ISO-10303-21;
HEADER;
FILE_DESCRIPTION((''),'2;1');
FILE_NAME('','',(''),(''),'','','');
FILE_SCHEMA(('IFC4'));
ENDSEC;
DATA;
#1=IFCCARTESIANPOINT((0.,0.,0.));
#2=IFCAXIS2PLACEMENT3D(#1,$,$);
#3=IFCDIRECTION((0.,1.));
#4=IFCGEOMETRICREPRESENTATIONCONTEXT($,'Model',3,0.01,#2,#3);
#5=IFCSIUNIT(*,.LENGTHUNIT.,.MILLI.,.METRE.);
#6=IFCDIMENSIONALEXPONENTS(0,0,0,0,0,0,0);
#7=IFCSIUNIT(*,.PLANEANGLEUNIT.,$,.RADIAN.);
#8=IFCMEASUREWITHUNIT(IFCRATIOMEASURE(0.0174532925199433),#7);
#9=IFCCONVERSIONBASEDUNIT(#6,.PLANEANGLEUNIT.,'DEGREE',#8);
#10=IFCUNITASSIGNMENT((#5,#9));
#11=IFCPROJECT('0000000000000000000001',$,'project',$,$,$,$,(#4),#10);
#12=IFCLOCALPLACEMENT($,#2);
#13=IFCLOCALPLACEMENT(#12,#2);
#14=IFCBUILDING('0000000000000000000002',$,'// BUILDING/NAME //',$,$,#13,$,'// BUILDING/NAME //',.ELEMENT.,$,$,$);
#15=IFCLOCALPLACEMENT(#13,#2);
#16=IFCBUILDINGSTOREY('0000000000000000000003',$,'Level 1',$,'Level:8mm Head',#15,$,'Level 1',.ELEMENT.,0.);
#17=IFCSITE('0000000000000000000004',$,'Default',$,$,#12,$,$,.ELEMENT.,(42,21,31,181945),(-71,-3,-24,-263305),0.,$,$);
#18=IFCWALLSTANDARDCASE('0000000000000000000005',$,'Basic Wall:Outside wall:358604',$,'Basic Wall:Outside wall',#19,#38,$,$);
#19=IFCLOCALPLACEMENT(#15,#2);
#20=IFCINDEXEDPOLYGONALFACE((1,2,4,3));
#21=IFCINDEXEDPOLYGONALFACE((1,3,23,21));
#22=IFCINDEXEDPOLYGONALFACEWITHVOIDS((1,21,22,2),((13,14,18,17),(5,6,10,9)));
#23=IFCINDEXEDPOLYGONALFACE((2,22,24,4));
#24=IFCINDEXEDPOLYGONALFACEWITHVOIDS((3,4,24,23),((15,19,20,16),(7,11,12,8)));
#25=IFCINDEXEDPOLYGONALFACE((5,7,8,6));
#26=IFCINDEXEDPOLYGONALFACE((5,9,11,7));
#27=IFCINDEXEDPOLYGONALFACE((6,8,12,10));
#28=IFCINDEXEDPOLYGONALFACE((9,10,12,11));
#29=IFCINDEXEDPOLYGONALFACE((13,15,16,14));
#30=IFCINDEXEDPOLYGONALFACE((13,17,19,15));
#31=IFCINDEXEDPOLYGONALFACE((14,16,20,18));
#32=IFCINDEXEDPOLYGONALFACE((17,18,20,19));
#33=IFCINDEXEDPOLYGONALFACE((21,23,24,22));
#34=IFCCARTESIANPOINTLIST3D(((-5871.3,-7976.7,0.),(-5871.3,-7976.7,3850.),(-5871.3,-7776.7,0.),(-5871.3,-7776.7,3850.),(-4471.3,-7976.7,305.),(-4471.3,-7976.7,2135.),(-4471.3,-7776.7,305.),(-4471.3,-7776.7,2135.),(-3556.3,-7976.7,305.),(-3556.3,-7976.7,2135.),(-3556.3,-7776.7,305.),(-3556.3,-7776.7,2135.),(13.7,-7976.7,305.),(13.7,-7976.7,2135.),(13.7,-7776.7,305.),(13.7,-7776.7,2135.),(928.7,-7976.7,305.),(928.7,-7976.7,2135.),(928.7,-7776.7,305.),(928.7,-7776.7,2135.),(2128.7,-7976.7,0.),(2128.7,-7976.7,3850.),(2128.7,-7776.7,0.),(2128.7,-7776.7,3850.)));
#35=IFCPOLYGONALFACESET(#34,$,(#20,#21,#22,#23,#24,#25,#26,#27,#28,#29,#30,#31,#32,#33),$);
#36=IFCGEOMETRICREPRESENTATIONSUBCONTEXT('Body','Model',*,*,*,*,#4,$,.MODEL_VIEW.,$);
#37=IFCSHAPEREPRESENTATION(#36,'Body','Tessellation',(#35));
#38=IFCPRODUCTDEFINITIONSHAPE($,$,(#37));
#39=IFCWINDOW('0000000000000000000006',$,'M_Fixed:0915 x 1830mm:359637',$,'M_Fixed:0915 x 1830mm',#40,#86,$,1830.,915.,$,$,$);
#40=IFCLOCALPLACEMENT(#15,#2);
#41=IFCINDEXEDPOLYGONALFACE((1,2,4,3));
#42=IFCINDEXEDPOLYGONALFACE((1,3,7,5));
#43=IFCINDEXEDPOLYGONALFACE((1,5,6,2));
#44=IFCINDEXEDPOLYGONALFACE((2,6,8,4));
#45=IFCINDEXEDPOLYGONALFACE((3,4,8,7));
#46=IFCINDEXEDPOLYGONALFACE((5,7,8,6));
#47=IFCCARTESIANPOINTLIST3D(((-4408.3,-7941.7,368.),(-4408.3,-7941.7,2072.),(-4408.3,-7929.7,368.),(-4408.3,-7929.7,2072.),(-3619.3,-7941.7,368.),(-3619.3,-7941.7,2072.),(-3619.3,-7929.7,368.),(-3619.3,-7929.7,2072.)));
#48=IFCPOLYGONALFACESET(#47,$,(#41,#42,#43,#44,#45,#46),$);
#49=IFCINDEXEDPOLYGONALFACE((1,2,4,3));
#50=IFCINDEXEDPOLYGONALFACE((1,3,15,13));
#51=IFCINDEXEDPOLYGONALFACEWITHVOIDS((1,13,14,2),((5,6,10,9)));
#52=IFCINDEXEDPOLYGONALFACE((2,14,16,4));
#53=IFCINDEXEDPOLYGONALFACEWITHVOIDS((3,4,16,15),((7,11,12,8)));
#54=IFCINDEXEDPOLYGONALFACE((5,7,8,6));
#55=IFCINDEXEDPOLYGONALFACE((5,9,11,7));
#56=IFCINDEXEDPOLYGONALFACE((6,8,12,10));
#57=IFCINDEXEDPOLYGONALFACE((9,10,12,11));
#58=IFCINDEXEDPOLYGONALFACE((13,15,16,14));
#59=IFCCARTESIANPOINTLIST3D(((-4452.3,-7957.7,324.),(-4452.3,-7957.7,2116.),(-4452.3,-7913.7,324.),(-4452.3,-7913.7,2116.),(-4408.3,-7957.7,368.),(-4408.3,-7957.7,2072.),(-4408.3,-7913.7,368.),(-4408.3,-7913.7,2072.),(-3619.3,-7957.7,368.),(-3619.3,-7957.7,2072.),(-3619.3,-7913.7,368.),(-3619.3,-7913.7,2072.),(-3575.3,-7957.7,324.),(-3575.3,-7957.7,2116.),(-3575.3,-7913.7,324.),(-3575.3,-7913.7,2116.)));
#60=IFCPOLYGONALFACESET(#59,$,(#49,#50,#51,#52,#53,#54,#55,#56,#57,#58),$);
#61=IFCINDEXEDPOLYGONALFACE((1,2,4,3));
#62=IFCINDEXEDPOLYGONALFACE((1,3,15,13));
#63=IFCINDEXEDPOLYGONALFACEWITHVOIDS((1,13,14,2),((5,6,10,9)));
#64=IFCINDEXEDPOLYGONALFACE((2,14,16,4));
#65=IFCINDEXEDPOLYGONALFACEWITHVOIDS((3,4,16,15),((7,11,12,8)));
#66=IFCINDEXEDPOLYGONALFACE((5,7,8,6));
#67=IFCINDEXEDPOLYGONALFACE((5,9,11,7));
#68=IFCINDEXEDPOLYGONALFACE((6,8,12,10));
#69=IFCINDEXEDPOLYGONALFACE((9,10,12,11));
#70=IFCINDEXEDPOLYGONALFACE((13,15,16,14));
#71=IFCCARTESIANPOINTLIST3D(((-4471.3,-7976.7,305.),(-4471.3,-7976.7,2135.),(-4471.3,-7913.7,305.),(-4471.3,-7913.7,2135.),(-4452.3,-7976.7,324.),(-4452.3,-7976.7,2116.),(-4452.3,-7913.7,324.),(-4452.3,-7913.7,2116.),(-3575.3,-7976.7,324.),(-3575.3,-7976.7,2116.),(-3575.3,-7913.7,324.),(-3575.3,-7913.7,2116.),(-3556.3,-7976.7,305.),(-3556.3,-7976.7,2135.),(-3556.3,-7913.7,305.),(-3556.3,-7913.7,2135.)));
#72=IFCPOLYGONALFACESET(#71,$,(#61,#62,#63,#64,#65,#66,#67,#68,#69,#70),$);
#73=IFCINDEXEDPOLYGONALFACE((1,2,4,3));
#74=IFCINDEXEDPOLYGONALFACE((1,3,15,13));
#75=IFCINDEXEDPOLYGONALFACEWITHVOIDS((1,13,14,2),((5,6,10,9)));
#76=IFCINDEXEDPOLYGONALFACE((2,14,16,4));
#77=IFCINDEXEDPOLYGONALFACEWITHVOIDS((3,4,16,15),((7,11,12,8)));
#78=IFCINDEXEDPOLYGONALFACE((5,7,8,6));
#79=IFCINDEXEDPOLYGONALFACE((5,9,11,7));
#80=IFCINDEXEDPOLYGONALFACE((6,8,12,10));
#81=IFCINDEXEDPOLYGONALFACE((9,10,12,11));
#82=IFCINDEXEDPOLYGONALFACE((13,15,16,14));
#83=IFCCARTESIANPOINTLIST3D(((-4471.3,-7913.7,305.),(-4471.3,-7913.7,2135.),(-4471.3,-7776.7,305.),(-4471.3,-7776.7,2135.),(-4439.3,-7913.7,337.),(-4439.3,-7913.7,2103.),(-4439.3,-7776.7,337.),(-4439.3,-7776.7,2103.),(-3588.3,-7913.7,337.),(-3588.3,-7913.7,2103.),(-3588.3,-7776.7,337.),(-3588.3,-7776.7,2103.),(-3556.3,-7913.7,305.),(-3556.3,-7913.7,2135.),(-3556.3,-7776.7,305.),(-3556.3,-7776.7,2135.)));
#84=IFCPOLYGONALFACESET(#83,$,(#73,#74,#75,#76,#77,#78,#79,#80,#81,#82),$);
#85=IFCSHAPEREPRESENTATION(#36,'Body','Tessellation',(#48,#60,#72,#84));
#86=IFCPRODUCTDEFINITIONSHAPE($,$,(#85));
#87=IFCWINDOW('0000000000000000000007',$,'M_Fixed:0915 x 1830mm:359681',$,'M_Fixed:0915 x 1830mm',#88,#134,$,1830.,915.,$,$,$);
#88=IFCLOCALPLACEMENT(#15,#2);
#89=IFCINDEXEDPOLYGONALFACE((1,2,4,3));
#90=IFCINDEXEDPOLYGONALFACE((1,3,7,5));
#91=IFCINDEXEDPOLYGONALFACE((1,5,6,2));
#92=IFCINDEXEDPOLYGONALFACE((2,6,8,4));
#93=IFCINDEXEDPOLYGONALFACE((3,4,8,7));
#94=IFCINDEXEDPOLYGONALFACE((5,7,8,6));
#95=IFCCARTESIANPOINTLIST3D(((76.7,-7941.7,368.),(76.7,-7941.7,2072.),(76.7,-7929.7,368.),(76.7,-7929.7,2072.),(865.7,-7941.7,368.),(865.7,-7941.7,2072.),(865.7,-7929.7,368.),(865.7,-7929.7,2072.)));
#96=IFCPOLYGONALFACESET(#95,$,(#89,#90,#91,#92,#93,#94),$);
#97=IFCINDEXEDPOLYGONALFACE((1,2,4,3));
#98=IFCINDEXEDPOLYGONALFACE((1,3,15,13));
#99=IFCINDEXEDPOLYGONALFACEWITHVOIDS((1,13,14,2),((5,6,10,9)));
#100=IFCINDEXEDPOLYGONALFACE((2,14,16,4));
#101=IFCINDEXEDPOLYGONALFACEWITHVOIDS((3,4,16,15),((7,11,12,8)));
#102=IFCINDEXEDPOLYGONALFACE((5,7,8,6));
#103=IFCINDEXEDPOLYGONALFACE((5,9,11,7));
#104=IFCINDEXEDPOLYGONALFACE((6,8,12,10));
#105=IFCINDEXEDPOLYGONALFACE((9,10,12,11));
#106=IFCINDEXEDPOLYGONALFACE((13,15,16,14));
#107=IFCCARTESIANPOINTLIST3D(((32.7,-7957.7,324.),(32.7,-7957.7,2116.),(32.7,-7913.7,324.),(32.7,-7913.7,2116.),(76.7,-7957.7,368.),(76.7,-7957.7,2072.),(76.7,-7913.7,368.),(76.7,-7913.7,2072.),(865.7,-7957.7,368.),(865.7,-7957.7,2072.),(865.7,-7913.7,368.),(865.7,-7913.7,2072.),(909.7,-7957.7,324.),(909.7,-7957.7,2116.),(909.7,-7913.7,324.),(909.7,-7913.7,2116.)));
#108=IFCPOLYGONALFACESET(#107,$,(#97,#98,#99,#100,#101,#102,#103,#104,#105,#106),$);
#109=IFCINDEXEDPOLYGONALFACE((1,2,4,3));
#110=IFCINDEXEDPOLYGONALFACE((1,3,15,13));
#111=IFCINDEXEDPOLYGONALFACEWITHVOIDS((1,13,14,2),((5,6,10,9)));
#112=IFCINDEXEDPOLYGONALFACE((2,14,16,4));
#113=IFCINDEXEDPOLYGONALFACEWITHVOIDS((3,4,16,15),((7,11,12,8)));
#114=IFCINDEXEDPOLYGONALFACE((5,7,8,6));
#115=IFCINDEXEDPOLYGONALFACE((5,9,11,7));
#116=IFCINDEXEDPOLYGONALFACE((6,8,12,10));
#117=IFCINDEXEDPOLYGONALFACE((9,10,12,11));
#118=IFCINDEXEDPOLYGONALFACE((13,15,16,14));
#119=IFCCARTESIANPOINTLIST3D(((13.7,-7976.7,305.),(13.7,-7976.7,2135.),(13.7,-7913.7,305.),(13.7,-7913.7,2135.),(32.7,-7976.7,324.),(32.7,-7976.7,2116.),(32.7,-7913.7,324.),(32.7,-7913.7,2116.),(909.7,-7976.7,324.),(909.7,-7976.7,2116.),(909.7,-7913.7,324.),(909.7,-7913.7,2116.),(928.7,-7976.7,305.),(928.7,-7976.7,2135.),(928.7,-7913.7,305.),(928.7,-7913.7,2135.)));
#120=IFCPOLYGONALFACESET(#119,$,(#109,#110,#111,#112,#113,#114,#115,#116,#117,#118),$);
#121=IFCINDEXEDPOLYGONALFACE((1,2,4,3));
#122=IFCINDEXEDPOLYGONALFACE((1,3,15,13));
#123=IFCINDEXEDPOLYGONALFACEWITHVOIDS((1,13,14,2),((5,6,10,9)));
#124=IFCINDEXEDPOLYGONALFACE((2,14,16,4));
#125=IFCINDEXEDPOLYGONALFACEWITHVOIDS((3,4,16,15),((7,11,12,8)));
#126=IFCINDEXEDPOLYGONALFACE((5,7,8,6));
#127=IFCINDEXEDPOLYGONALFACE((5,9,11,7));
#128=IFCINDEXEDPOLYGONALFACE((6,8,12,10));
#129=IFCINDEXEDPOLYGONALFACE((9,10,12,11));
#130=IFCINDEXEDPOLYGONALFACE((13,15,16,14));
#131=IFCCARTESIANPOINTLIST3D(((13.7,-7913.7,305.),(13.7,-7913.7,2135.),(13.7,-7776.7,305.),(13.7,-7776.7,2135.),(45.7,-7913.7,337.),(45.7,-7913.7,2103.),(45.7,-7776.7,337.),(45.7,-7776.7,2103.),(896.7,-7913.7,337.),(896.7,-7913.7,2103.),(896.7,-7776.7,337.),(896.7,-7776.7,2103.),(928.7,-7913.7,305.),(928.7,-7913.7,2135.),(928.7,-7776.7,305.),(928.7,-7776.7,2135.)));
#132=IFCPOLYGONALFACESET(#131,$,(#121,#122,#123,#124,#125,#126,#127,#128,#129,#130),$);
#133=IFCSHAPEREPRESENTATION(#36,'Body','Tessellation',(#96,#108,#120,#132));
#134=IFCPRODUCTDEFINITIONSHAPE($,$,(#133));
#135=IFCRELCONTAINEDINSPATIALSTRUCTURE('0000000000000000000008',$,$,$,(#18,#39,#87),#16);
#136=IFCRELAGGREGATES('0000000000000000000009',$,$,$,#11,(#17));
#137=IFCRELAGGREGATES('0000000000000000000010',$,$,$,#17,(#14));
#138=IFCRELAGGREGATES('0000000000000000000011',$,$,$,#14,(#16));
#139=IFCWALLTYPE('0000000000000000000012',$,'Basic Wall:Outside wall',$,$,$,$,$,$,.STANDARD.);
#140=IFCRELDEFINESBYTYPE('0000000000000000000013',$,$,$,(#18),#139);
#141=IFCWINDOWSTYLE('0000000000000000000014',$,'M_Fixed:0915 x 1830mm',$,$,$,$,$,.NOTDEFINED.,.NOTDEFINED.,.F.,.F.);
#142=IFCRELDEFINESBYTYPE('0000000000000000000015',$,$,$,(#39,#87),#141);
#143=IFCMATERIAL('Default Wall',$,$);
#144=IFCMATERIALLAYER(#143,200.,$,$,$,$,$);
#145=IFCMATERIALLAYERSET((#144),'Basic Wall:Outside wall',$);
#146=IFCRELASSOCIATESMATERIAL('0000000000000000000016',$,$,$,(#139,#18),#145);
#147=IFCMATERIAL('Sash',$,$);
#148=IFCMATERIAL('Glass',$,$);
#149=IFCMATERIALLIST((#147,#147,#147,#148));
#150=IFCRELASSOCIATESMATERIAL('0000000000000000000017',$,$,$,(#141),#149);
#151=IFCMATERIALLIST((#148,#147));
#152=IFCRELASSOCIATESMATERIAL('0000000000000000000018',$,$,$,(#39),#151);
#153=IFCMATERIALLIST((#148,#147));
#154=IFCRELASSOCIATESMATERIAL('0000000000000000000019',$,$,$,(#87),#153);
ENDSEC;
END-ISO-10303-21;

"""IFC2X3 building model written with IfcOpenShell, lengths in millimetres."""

from ifc_helpers import new_model, entity, si_unit, converted_unit, direction, frame, frame_2d, origin, place, context, subcontext, project, spatial, polyline, rectangle, outline, extrude, clip, halfspace, bounded_halfspace, source, transform, mapped, material, material_list, layer, layer_set, layer_usage, type_object, type_shapes, element, fill, save


model = new_model("IFC2X3")

# Units and contexts
model_context = context("Model", 3, precision=0.01, world=origin(), true_north=direction((0.0, 1.0)))
body_context = subcontext(model_context, "Body", "Model", "MODEL_VIEW")
ifc_project = project(units=[si_unit("LENGTHUNIT", "METRE", prefix="MILLI"), converted_unit("PLANEANGLEUNIT", "DEGREE", entity("IfcRatioMeasure", 0.0174532925199433), si_unit("PLANEANGLEUNIT", "RADIAN"), dimensions=[0, 0, 0, 0, 0, 0, 0])], contexts=[model_context])

# Site, building, storey
site_placement = place(None, origin())
site = spatial("IfcSite", under=ifc_project, at=site_placement, Name="Default", CompositionType="ELEMENT", RefLatitude=(42, 21, 31, 181945), RefLongitude=(-71, -3, -24, -263305), RefElevation=0.0)
building_placement = place(site_placement, origin())
building = spatial("IfcBuilding", under=site, at=building_placement, Name="// BUILDING/NAME //", LongName="// BUILDING/NAME //", CompositionType="ELEMENT")
storey_placement = place(building_placement, origin())
storey = spatial("IfcBuildingStorey", under=building, at=storey_placement, Name="Level 1", ObjectType="Level:8mm Head", LongName="Level 1", CompositionType="ELEMENT", Elevation=0.0)

# Shared definitions
ifc_material_1 = material(Name="Default Wall")
ifc_layer_1 = layer(ifc_material_1, 200.0)
ifc_layer_set_1 = layer_set([ifc_layer_1], Name="Basic Wall:Outside wall")
wall_type_1 = type_object("IfcWallType", Name="Basic Wall:Outside wall", PredefinedType="STANDARD", material=ifc_layer_set_1)
ifc_material_2 = material(Name="Glass")
ifc_material_3 = material(Name="Sash")
ifc_material_list_1 = material_list([ifc_material_3, ifc_material_3, ifc_material_3, ifc_material_2])
window_style = type_object("IfcWindowStyle", Name="M_Fixed:0915 x 1830mm", ConstructionType="NOTDEFINED", OperationType="NOTDEFINED", ParameterTakesPrecedence=False, Sizeable=False, material=ifc_material_list_1)
shared_shape_1 = source(origin(), body_context, "Body", "SweptSolid", [
    extrude(rectangle(XDim=12.0, YDim=789.0, at=frame_2d((0.0, 0.0), x_axis=(1.0, 0.0))), frame((457.5, 159.0, 63.0), z_axis=(0.0, 0.0, 1.0), x_axis=(0.0, -1.0, 0.0)), (0.0, 0.0, 1.0), 1704.0),
    extrude(outline(polyline([(-438.5, -896.0), (438.5, -896.0), (438.5, 896.0), (-438.5, 896.0), (-438.5, -896.0)]), holes=[polyline([(-394.5, -852.0), (-394.5, 852.0), (394.5, 852.0), (394.5, -852.0), (-394.5, -852.0)])]), frame((457.5, 137.0, 915.0), z_axis=(0.0, 1.0, 0.0), x_axis=(1.0, 0.0, 0.0)), (0.0, 0.0, 1.0), 44.0),
    extrude(outline(polyline([(-457.5, -915.0), (457.5, -915.0), (457.5, 915.0), (-457.5, 915.0), (-457.5, -915.0)]), holes=[polyline([(-438.5, -896.0), (-438.5, 896.0), (438.5, 896.0), (438.5, -896.0), (-438.5, -896.0)])]), frame((457.5, 137.0, 915.0), z_axis=(0.0, 1.0, 0.0), x_axis=(1.0, 0.0, 0.0)), (0.0, 0.0, 1.0), 63.0),
    extrude(outline(polyline([(-457.5, -915.0), (457.5, -915.0), (457.5, 915.0), (-457.5, 915.0), (-457.5, -915.0)]), holes=[polyline([(-425.5, -883.0), (-425.5, 883.0), (425.5, 883.0), (425.5, -883.0), (-425.5, -883.0)])]), frame((457.5, 0.0, 915.0), z_axis=(0.0, 1.0, 0.0), x_axis=(1.0, 0.0, 0.0)), (0.0, 0.0, 1.0), 137.0),
])
type_shapes(window_style, [shared_shape_1])

# Wall, openings, windows
ifc_layer_usage_1 = layer_usage(ifc_layer_set_1, "AXIS2", "NEGATIVE", 100.0)
wall_1_placement = place(storey_placement, frame((2128.7, -7876.7, 0.0), z_axis=(0.0, 0.0, 1.0), x_axis=(-1.0, 0.0, 0.0)))
wall_1 = element("IfcWallStandardCase", 1, at=wall_1_placement, inside=storey, type_object=wall_type_1, material=ifc_layer_usage_1, Name="Basic Wall:Outside wall:358604", ObjectType="Basic Wall:Outside wall", context=body_context, shape_type="Clipping", body=[
    clip(clip(extrude(rectangle(XDim=8000.0, YDim=200.0, at=frame_2d((4000.0, 0.0), x_axis=(-1.0, 0.0))), origin(), (0.0, 0.0, 1.0), 3850.0), bounded_halfspace(frame((0.0, -100.0, 3850.0), z_axis=(0.0, 0.0, -1.0), x_axis=(0.0, 1.0, 0.0)), True, frame((0.0, -100.0, 3850.0), z_axis=(0.0, 0.0, -1.0), x_axis=(0.0, 1.0, 0.0)), polyline([(0.0, 0.0), (200.0, 0.0), (200.0, 8000.0), (0.0, 8000.0), (0.0, 7800.0), (0.0, 0.0)]))), halfspace(origin(), True)),
])
opening_1_placement = place(wall_1_placement, frame((5685.0, -100.0, 305.0)))
opening_1 = element("IfcOpeningElement", 2, at=opening_1_placement, cuts=wall_1, ObjectType="Opening", context=body_context, shape_type="SweptSolid", body=[
    extrude(rectangle(XDim=1830.0, YDim=915.0, at=frame_2d((915.0, 457.5), x_axis=(1.0, 0.0))), frame((0.0, 0.0, 0.0), z_axis=(0.0, 1.0, 0.0), x_axis=(0.0, 0.0, 1.0)), (0.0, 0.0, 1.0), 200.0),
])
opening_2_placement = place(wall_1_placement, frame((1200.0, -100.0, 305.0)))
opening_2 = element("IfcOpeningElement", 3, at=opening_2_placement, cuts=wall_1, ObjectType="Opening", context=body_context, shape_type="SweptSolid", body=[
    extrude(rectangle(XDim=1830.0, YDim=915.0, at=frame_2d((915.0, 457.5), x_axis=(1.0, 0.0))), frame((0.0, 0.0, 0.0), z_axis=(0.0, 1.0, 0.0), x_axis=(0.0, 0.0, 1.0)), (0.0, 0.0, 1.0), 200.0),
])
ifc_material_list_2 = material_list([ifc_material_2, ifc_material_3])
window_1_placement = place(opening_1_placement, origin())
window_1 = element("IfcWindow", 4, at=window_1_placement, inside=storey, type_object=window_style, material=ifc_material_list_2, Name="M_Fixed:0915 x 1830mm:359637", ObjectType="M_Fixed:0915 x 1830mm", OverallHeight=1830.0, OverallWidth=915.0, context=body_context, shape_type="MappedRepresentation", body=[
    mapped(shared_shape_1, transform((0.0, 0.0, 0.0), scale=1.0)),
])
fill(opening_1, window_1)
ifc_material_list_3 = material_list([ifc_material_2, ifc_material_3])
window_2_placement = place(opening_2_placement, origin())
window_2 = element("IfcWindow", 5, at=window_2_placement, inside=storey, type_object=window_style, material=ifc_material_list_3, Name="M_Fixed:0915 x 1830mm:359681", ObjectType="M_Fixed:0915 x 1830mm", OverallHeight=1830.0, OverallWidth=915.0, context=body_context, shape_type="MappedRepresentation", body=[
    mapped(shared_shape_1, transform((0.0, 0.0, 0.0), scale=1.0)),
])
fill(opening_2, window_2)

save(model, "model.ifc")
